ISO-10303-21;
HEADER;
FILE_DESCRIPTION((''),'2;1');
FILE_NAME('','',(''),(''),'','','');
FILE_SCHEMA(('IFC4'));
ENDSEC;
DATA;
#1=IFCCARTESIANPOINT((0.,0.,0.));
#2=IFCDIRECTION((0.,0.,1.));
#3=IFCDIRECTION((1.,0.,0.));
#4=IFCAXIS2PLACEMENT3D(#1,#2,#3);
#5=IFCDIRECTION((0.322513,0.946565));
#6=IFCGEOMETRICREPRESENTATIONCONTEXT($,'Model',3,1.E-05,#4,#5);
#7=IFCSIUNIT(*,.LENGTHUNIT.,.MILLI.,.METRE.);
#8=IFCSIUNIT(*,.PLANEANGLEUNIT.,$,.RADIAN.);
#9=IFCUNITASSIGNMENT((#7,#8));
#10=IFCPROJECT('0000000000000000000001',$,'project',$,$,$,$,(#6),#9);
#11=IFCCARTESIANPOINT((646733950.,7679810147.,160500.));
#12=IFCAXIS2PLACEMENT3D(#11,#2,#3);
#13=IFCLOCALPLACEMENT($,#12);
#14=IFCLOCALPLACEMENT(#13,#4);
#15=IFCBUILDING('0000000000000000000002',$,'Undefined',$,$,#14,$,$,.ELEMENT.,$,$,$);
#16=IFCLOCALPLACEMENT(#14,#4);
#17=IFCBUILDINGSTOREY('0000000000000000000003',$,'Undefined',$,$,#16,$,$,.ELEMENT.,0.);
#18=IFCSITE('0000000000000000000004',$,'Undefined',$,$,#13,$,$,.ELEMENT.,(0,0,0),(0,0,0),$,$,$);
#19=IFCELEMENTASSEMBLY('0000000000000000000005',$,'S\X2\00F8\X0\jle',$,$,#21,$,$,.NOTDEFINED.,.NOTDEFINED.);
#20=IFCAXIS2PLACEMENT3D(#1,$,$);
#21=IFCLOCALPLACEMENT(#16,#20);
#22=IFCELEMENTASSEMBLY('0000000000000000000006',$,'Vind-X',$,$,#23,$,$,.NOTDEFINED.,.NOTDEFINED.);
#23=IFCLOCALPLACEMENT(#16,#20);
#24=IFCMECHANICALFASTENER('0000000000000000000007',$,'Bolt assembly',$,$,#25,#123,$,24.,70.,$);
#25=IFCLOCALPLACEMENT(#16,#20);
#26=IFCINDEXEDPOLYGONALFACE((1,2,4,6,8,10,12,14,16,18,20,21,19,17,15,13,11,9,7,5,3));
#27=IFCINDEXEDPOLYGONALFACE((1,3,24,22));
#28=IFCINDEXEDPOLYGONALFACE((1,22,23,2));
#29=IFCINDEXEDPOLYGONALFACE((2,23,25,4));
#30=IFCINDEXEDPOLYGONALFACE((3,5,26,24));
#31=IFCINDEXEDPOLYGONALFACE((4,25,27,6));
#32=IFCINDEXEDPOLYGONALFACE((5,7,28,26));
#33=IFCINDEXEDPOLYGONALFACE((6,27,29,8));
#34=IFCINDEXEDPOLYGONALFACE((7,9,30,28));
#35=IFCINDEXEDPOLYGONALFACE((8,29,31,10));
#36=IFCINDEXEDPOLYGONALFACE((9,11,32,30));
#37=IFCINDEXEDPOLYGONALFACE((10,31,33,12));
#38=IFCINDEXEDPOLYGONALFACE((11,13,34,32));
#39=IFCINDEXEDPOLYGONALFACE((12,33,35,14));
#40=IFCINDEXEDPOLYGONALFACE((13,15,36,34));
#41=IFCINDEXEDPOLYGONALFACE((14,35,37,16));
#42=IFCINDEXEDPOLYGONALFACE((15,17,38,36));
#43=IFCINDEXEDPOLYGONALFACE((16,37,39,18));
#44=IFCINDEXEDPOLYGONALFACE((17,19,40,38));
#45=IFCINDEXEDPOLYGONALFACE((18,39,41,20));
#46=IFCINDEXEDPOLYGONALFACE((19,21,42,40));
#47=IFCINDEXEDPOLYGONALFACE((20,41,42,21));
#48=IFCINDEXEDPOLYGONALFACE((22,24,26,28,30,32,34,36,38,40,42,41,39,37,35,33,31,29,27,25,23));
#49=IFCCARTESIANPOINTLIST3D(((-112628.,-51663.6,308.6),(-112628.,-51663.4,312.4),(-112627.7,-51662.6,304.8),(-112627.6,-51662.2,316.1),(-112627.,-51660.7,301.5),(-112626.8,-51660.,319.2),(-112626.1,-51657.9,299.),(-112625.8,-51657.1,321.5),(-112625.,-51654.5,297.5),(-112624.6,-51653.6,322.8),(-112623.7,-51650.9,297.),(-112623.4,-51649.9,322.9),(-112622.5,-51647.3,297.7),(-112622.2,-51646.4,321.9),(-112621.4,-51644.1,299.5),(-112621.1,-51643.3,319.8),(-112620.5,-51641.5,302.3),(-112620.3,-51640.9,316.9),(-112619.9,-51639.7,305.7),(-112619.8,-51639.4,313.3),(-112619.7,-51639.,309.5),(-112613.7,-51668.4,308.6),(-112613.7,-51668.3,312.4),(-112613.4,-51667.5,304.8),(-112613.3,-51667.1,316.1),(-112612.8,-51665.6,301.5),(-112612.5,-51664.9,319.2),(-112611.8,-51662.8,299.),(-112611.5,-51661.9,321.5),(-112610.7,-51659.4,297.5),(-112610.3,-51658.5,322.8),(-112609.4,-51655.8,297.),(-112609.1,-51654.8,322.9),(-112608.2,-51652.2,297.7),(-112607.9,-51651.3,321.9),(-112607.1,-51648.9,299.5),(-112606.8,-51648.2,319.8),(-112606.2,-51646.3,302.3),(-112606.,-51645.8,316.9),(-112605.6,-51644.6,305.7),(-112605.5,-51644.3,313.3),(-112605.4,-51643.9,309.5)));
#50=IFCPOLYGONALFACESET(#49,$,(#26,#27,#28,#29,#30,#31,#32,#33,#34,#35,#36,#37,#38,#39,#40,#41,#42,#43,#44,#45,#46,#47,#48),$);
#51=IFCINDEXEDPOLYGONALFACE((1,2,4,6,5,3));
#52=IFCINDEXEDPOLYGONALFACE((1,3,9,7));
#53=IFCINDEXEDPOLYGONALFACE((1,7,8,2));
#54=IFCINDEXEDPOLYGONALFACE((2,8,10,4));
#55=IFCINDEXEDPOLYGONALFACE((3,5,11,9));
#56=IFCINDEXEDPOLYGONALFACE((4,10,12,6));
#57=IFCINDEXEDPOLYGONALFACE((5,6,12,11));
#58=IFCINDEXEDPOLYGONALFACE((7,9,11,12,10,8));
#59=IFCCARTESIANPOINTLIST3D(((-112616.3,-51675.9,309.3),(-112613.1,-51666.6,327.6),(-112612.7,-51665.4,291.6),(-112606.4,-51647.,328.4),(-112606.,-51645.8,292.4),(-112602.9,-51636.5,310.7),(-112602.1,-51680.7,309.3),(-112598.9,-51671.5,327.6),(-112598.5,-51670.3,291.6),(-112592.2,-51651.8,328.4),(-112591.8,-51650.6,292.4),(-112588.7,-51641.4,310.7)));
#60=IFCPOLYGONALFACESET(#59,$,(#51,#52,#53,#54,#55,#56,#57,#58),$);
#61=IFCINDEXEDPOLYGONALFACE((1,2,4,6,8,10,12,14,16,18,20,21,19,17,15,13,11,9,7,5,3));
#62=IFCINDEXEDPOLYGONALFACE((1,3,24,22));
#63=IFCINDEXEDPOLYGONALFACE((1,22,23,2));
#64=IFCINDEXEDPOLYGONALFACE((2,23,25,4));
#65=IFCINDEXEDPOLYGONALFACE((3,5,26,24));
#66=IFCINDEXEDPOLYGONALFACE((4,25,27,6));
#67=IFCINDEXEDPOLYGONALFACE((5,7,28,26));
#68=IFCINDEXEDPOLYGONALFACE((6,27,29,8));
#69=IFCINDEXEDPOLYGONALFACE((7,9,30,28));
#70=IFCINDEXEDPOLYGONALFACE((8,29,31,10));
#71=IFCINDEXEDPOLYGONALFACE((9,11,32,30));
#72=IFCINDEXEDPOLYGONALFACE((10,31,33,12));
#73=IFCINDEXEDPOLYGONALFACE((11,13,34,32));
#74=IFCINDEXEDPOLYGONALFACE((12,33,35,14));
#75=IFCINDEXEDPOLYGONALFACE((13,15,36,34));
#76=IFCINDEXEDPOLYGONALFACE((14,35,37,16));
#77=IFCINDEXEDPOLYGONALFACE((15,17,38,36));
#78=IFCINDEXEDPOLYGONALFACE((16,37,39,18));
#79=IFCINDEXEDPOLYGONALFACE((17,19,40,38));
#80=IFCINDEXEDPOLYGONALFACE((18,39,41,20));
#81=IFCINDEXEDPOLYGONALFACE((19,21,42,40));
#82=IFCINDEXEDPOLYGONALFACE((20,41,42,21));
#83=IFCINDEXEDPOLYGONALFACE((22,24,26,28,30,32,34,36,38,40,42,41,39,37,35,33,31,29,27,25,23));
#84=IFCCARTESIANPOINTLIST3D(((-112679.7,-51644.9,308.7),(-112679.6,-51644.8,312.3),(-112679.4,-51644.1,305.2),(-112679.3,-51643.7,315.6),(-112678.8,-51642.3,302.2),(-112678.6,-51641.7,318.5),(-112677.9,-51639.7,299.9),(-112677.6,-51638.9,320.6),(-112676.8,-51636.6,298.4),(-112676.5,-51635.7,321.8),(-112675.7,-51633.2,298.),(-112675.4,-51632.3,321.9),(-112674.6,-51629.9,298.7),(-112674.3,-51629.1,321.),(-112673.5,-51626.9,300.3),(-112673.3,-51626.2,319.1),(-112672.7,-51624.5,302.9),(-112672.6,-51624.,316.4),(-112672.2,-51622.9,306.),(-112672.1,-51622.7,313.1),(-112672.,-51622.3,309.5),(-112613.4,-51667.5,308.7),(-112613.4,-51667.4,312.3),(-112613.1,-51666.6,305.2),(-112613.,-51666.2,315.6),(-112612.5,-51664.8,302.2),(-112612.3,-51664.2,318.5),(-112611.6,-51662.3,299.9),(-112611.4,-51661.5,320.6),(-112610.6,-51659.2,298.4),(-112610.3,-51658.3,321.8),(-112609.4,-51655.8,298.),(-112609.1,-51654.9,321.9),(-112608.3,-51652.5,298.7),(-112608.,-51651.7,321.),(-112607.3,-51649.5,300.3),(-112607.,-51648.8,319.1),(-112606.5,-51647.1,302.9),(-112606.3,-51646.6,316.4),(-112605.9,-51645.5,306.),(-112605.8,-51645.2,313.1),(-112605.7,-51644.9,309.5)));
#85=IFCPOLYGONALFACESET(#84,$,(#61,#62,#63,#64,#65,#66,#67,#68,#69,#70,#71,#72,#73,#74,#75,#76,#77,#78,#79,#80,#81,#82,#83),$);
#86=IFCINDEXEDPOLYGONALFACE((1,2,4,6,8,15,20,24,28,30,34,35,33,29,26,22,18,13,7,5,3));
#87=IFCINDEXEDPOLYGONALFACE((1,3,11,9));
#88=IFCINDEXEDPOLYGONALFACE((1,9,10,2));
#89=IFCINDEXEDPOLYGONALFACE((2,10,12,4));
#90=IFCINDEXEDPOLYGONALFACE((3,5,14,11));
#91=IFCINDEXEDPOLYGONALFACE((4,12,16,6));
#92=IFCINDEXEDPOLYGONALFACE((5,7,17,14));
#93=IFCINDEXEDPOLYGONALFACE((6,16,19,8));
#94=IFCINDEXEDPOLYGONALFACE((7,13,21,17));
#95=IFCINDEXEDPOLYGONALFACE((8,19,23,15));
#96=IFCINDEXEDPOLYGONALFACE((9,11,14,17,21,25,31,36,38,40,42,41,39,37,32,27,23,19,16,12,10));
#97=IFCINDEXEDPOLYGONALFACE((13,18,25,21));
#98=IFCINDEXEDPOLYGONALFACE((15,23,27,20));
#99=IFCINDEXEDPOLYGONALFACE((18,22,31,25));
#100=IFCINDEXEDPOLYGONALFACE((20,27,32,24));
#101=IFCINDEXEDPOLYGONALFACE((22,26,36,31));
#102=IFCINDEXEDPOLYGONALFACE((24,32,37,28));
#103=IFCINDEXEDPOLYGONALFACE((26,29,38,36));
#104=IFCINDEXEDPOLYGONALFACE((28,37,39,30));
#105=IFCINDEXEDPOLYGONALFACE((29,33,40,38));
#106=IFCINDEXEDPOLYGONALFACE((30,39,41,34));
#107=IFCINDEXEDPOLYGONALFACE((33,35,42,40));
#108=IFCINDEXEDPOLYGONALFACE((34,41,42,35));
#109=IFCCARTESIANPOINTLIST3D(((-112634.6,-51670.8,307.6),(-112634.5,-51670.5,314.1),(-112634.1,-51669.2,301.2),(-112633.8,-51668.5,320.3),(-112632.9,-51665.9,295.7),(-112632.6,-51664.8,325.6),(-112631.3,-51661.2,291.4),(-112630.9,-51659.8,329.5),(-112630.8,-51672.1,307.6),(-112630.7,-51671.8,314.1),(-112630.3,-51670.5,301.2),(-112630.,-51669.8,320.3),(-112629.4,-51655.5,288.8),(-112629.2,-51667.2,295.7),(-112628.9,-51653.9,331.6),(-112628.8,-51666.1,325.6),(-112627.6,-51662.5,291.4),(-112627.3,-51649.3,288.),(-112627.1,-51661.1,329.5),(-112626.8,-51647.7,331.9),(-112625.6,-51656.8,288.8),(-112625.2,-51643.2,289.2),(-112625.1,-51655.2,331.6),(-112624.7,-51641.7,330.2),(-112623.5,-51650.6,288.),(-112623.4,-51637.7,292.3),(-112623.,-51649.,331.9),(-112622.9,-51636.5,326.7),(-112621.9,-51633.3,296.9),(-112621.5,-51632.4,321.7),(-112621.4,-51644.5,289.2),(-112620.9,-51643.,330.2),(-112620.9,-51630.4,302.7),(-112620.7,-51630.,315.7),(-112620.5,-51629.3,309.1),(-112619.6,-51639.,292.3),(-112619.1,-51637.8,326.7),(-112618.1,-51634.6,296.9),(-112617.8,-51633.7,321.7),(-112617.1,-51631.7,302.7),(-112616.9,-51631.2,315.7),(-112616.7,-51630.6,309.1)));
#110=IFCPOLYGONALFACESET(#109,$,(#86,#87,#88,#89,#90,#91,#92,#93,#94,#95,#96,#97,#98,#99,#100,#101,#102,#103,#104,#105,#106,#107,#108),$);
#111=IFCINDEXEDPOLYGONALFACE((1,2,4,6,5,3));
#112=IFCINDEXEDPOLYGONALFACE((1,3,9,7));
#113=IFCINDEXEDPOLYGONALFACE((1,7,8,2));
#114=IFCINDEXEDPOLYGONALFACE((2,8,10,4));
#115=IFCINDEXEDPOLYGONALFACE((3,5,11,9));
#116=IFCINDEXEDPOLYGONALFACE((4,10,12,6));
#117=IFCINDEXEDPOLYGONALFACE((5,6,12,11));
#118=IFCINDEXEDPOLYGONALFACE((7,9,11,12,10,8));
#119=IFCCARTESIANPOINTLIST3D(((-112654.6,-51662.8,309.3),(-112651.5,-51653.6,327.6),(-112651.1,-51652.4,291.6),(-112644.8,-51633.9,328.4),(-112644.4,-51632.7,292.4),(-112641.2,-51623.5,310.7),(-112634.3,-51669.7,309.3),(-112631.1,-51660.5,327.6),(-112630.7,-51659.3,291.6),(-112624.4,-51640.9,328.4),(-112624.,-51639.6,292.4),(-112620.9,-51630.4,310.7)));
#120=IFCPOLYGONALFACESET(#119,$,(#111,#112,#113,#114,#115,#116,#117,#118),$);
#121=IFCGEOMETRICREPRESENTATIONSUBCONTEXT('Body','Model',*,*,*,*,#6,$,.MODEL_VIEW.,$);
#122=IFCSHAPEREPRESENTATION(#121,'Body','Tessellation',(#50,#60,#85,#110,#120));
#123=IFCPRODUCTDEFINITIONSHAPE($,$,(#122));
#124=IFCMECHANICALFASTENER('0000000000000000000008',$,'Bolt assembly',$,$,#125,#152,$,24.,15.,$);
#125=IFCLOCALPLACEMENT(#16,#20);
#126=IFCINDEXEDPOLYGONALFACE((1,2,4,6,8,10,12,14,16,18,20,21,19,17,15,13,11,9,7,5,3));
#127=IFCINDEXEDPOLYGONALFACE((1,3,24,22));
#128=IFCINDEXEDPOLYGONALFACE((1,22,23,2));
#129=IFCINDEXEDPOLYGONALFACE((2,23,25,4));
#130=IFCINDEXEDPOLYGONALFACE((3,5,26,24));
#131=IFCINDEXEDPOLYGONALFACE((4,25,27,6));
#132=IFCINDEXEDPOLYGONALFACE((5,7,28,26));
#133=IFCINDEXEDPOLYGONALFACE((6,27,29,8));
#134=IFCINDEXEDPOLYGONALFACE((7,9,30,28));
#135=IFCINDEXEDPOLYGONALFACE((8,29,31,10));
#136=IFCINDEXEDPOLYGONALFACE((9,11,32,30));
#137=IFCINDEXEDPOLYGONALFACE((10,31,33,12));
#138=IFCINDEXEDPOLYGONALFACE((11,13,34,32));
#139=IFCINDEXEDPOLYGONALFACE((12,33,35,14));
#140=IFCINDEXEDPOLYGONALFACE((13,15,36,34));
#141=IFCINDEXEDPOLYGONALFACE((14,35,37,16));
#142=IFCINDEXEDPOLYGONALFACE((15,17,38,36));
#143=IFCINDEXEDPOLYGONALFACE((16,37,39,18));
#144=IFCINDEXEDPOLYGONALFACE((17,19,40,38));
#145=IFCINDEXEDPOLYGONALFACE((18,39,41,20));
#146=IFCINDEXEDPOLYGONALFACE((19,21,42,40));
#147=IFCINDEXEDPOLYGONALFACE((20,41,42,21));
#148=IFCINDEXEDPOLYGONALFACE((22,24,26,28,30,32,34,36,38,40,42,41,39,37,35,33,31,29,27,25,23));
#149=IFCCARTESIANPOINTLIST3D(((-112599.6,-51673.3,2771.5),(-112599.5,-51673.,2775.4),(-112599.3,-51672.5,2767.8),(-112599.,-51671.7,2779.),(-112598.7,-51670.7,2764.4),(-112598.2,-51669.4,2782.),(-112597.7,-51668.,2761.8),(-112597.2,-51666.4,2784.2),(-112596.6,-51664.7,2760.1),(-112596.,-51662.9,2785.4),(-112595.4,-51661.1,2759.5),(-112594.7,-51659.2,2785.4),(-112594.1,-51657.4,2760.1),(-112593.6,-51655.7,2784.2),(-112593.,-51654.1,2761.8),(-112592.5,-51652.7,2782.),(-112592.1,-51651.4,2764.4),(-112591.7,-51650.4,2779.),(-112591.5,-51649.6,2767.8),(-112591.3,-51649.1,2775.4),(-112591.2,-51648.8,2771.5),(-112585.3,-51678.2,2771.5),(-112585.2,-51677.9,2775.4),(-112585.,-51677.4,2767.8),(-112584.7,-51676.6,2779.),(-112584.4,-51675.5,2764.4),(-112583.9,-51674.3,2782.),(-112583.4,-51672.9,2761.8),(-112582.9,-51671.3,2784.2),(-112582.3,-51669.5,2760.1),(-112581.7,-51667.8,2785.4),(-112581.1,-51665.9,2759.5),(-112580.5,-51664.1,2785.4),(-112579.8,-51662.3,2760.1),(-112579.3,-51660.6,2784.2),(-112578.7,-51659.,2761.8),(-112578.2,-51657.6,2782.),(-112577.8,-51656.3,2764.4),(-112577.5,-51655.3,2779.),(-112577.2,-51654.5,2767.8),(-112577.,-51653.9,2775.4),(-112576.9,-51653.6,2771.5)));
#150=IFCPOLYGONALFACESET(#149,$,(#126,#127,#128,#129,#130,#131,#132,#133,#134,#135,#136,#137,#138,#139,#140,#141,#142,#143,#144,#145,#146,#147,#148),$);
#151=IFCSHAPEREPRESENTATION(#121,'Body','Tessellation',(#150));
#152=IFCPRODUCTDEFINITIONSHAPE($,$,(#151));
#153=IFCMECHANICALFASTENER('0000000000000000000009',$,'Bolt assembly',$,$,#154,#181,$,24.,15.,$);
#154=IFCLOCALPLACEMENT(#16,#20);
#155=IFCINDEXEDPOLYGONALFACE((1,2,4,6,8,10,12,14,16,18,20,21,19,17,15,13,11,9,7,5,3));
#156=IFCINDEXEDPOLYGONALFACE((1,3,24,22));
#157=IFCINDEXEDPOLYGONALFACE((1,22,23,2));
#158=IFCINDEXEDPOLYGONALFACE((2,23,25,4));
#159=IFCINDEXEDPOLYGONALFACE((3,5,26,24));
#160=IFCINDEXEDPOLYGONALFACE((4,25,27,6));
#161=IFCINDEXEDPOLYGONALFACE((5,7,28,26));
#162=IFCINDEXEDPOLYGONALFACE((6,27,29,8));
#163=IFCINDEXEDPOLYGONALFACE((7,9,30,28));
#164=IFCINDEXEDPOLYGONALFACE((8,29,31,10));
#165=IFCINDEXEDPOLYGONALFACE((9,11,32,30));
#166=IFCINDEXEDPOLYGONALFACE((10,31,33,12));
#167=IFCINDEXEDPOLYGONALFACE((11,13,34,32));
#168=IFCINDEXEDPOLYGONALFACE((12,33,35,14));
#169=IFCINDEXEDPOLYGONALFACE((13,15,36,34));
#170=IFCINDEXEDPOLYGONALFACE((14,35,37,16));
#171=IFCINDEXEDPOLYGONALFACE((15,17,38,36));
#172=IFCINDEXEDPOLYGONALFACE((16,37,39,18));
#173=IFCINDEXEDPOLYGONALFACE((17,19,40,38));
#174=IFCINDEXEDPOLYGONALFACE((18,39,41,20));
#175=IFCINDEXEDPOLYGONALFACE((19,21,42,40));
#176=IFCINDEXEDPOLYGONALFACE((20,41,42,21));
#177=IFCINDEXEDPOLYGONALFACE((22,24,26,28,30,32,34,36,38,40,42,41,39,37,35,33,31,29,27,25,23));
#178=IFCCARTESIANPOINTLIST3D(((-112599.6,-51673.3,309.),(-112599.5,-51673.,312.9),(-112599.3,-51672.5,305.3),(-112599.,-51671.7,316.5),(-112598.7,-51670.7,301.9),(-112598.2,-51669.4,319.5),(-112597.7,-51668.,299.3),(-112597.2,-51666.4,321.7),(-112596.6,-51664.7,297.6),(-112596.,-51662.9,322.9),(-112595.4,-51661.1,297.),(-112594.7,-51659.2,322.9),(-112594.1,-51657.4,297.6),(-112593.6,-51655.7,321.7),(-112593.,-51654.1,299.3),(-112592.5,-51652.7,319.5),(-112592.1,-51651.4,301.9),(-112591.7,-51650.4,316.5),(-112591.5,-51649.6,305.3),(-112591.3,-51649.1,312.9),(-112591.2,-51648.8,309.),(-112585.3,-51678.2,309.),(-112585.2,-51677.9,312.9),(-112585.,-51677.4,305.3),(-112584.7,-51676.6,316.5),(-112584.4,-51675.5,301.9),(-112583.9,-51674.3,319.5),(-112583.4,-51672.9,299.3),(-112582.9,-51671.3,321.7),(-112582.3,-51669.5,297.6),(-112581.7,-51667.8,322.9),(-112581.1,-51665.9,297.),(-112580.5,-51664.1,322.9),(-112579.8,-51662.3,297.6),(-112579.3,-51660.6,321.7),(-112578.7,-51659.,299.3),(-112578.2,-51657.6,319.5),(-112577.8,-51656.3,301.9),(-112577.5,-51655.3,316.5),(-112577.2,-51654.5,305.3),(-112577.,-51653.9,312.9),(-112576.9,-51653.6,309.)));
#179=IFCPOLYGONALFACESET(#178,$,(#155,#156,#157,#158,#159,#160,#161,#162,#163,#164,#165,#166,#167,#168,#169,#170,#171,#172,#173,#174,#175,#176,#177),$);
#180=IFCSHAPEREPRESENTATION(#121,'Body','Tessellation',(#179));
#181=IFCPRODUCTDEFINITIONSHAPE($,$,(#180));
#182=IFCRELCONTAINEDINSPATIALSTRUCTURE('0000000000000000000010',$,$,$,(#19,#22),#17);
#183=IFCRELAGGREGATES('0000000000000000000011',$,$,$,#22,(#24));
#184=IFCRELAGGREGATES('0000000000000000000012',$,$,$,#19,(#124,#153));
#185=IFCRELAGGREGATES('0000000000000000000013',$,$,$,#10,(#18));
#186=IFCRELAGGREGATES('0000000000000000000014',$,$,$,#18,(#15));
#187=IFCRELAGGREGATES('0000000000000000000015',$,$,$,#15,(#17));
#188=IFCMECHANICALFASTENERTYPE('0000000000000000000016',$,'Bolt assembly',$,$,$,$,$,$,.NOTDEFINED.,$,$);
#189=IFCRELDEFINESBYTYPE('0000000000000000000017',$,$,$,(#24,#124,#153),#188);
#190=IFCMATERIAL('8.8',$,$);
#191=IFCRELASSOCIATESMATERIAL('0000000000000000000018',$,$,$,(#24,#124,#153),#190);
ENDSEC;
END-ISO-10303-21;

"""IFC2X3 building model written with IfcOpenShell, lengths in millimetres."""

from ifc_helpers import new_model, si_unit, direction, frame, origin_with_axes, origin_2d_with_axis, place, context, subcontext, project, spatial, polyline, circle, outline, extrude, source, transform, mapped, material, type_object, element, aggregate, save


model = new_model("IFC2X3")

# Units and contexts
model_context = context("Model", 3, precision=1e-05, world=origin_with_axes(), true_north=direction((0.322513, 0.946565)))
body_context = subcontext(model_context, "Body", "Model", "MODEL_VIEW")
ifc_project = project(units=[si_unit("LENGTHUNIT", "METRE", prefix="MILLI"), si_unit("PLANEANGLEUNIT", "RADIAN")], contexts=[model_context])

# Site, building, storey
site_placement = place(None, frame((646733950.0, 7679810147.0, 160500.0), z_axis=(0.0, 0.0, 1.0), x_axis=(1.0, 0.0, 0.0)))
site = spatial("IfcSite", under=ifc_project, at=site_placement, Name="Undefined", CompositionType="ELEMENT", RefLatitude=(0, 0, 0), RefLongitude=(0, 0, 0))
building_placement = place(site_placement, origin_with_axes())
building = spatial("IfcBuilding", under=site, at=building_placement, Name="Undefined", CompositionType="ELEMENT")
storey_placement = place(building_placement, origin_with_axes())
storey = spatial("IfcBuildingStorey", under=building, at=storey_placement, Name="Undefined", CompositionType="ELEMENT", Elevation=0.0)

# Element assembly
assembly_1_placement = place(storey_placement, origin_with_axes())
assembly_1 = element("IfcElementAssembly", 1, at=assembly_1_placement, inside=storey, Name="Søjle", AssemblyPlace="NOTDEFINED", PredefinedType="NOTDEFINED")

# Element assembly
assembly_2_placement = place(storey_placement, origin_with_axes())
assembly_2 = element("IfcElementAssembly", 2, at=assembly_2_placement, inside=storey, Name="Vind-X", AssemblyPlace="NOTDEFINED", PredefinedType="NOTDEFINED")

# Mechanical fasteners
ifc_material_1 = material(Name="8.8")
mechanical_fastener_type = type_object("IfcMechanicalFastenerType", Name="Bolt assembly")
shared_shape_1 = source(origin_with_axes(), body_context, "Body", "SweptSolid", [
    extrude(circle(Radius=13.0, at=origin_2d_with_axis()), frame((0.0, 0.0, 0.0), z_axis=(0.0, 1.0, 0.0), x_axis=(1.0, 0.0, 0.0)), (0.0, 0.0, 1.0), 15.1),
    extrude(outline(polyline([(18.0, -10.4), (18.0, 10.4), (0.0, 20.8), (-18.0, 10.4), (-18.0, -10.4), (0.0, -20.8), (18.0, -10.4)])), frame((0.0, -15.0, 0.0), z_axis=(0.0, 1.0, 0.0), x_axis=(1.0, 0.0, 0.0)), (0.0, 0.0, 1.0), 15.0),
    extrude(circle(Radius=12.0, at=origin_2d_with_axis()), frame((0.0, 0.0, 0.0), z_axis=(0.0, 1.0, 0.0), x_axis=(1.0, 0.0, 0.0)), (0.0, 0.0, 1.0), 70.0),
    extrude(circle(Radius=22.0, at=origin_2d_with_axis()), frame((0.0, 15.0, 0.0), z_axis=(0.0, 1.0, 0.0), x_axis=(1.0, 0.0, 0.0)), (0.0, 0.0, 1.0), 4.0),
    extrude(outline(polyline([(18.0, -10.4), (18.0, 10.4), (0.0, 20.8), (-18.0, 10.4), (-18.0, -10.4), (0.0, -20.8), (18.0, -10.4)])), frame((0.0, 19.0, 0.0), z_axis=(0.0, 1.0, 0.0), x_axis=(1.0, 0.0, 0.0)), (0.0, 0.0, 1.0), 21.5),
])
mechanical_fastener_1_placement = place(assembly_2_placement, frame((-112609.6, -51656.2, 310.0), z_axis=(-0.151189, -0.443735, -0.883313), x_axis=(-0.28488, -0.836113, 0.468784)))
mechanical_fastener_1 = element("IfcMechanicalFastener", 3, at=mechanical_fastener_1_placement, type_object=mechanical_fastener_type, material=ifc_material_1, Name="Bolt assembly", NominalDiameter=24.0, NominalLength=70.0, context=body_context, shape_type="MappedRepresentation", body=[
    mapped(shared_shape_1, transform((0.0, 0.0, 0.0))),
])
aggregate(assembly_2, [mechanical_fastener_1])
shared_shape_2 = source(origin_with_axes(), body_context, "Body", "SweptSolid", [
    extrude(circle(Radius=13.0, at=origin_2d_with_axis()), frame((0.0, -7.5, 0.0), z_axis=(0.0, 1.0, 0.0), x_axis=(1.0, 0.0, 0.0)), (0.0, 0.0, 1.0), 15.1),
])
mechanical_fastener_2_placement = place(assembly_1_placement, frame((-112588.3, -51663.5, 2772.5), z_axis=(-0.322513, -0.946565, 0.0), x_axis=(0.0, 0.0, -1.0)))
mechanical_fastener_2 = element("IfcMechanicalFastener", 4, at=mechanical_fastener_2_placement, type_object=mechanical_fastener_type, material=ifc_material_1, Name="Bolt assembly", NominalDiameter=24.0, NominalLength=15.0, context=body_context, shape_type="MappedRepresentation", body=[
    mapped(shared_shape_2, transform((0.0, 0.0, 0.0))),
])
mechanical_fastener_3_placement = place(assembly_1_placement, frame((-112588.3, -51663.5, 310.0), z_axis=(-0.322513, -0.946565, 0.0), x_axis=(0.0, 0.0, -1.0)))
mechanical_fastener_3 = element("IfcMechanicalFastener", 5, at=mechanical_fastener_3_placement, type_object=mechanical_fastener_type, material=ifc_material_1, Name="Bolt assembly", NominalDiameter=24.0, NominalLength=15.0, context=body_context, shape_type="MappedRepresentation", body=[
    mapped(shared_shape_2, transform((0.0, 0.0, 0.0))),
])
aggregate(assembly_1, [mechanical_fastener_2, mechanical_fastener_3])

save(model, "model.ifc")
